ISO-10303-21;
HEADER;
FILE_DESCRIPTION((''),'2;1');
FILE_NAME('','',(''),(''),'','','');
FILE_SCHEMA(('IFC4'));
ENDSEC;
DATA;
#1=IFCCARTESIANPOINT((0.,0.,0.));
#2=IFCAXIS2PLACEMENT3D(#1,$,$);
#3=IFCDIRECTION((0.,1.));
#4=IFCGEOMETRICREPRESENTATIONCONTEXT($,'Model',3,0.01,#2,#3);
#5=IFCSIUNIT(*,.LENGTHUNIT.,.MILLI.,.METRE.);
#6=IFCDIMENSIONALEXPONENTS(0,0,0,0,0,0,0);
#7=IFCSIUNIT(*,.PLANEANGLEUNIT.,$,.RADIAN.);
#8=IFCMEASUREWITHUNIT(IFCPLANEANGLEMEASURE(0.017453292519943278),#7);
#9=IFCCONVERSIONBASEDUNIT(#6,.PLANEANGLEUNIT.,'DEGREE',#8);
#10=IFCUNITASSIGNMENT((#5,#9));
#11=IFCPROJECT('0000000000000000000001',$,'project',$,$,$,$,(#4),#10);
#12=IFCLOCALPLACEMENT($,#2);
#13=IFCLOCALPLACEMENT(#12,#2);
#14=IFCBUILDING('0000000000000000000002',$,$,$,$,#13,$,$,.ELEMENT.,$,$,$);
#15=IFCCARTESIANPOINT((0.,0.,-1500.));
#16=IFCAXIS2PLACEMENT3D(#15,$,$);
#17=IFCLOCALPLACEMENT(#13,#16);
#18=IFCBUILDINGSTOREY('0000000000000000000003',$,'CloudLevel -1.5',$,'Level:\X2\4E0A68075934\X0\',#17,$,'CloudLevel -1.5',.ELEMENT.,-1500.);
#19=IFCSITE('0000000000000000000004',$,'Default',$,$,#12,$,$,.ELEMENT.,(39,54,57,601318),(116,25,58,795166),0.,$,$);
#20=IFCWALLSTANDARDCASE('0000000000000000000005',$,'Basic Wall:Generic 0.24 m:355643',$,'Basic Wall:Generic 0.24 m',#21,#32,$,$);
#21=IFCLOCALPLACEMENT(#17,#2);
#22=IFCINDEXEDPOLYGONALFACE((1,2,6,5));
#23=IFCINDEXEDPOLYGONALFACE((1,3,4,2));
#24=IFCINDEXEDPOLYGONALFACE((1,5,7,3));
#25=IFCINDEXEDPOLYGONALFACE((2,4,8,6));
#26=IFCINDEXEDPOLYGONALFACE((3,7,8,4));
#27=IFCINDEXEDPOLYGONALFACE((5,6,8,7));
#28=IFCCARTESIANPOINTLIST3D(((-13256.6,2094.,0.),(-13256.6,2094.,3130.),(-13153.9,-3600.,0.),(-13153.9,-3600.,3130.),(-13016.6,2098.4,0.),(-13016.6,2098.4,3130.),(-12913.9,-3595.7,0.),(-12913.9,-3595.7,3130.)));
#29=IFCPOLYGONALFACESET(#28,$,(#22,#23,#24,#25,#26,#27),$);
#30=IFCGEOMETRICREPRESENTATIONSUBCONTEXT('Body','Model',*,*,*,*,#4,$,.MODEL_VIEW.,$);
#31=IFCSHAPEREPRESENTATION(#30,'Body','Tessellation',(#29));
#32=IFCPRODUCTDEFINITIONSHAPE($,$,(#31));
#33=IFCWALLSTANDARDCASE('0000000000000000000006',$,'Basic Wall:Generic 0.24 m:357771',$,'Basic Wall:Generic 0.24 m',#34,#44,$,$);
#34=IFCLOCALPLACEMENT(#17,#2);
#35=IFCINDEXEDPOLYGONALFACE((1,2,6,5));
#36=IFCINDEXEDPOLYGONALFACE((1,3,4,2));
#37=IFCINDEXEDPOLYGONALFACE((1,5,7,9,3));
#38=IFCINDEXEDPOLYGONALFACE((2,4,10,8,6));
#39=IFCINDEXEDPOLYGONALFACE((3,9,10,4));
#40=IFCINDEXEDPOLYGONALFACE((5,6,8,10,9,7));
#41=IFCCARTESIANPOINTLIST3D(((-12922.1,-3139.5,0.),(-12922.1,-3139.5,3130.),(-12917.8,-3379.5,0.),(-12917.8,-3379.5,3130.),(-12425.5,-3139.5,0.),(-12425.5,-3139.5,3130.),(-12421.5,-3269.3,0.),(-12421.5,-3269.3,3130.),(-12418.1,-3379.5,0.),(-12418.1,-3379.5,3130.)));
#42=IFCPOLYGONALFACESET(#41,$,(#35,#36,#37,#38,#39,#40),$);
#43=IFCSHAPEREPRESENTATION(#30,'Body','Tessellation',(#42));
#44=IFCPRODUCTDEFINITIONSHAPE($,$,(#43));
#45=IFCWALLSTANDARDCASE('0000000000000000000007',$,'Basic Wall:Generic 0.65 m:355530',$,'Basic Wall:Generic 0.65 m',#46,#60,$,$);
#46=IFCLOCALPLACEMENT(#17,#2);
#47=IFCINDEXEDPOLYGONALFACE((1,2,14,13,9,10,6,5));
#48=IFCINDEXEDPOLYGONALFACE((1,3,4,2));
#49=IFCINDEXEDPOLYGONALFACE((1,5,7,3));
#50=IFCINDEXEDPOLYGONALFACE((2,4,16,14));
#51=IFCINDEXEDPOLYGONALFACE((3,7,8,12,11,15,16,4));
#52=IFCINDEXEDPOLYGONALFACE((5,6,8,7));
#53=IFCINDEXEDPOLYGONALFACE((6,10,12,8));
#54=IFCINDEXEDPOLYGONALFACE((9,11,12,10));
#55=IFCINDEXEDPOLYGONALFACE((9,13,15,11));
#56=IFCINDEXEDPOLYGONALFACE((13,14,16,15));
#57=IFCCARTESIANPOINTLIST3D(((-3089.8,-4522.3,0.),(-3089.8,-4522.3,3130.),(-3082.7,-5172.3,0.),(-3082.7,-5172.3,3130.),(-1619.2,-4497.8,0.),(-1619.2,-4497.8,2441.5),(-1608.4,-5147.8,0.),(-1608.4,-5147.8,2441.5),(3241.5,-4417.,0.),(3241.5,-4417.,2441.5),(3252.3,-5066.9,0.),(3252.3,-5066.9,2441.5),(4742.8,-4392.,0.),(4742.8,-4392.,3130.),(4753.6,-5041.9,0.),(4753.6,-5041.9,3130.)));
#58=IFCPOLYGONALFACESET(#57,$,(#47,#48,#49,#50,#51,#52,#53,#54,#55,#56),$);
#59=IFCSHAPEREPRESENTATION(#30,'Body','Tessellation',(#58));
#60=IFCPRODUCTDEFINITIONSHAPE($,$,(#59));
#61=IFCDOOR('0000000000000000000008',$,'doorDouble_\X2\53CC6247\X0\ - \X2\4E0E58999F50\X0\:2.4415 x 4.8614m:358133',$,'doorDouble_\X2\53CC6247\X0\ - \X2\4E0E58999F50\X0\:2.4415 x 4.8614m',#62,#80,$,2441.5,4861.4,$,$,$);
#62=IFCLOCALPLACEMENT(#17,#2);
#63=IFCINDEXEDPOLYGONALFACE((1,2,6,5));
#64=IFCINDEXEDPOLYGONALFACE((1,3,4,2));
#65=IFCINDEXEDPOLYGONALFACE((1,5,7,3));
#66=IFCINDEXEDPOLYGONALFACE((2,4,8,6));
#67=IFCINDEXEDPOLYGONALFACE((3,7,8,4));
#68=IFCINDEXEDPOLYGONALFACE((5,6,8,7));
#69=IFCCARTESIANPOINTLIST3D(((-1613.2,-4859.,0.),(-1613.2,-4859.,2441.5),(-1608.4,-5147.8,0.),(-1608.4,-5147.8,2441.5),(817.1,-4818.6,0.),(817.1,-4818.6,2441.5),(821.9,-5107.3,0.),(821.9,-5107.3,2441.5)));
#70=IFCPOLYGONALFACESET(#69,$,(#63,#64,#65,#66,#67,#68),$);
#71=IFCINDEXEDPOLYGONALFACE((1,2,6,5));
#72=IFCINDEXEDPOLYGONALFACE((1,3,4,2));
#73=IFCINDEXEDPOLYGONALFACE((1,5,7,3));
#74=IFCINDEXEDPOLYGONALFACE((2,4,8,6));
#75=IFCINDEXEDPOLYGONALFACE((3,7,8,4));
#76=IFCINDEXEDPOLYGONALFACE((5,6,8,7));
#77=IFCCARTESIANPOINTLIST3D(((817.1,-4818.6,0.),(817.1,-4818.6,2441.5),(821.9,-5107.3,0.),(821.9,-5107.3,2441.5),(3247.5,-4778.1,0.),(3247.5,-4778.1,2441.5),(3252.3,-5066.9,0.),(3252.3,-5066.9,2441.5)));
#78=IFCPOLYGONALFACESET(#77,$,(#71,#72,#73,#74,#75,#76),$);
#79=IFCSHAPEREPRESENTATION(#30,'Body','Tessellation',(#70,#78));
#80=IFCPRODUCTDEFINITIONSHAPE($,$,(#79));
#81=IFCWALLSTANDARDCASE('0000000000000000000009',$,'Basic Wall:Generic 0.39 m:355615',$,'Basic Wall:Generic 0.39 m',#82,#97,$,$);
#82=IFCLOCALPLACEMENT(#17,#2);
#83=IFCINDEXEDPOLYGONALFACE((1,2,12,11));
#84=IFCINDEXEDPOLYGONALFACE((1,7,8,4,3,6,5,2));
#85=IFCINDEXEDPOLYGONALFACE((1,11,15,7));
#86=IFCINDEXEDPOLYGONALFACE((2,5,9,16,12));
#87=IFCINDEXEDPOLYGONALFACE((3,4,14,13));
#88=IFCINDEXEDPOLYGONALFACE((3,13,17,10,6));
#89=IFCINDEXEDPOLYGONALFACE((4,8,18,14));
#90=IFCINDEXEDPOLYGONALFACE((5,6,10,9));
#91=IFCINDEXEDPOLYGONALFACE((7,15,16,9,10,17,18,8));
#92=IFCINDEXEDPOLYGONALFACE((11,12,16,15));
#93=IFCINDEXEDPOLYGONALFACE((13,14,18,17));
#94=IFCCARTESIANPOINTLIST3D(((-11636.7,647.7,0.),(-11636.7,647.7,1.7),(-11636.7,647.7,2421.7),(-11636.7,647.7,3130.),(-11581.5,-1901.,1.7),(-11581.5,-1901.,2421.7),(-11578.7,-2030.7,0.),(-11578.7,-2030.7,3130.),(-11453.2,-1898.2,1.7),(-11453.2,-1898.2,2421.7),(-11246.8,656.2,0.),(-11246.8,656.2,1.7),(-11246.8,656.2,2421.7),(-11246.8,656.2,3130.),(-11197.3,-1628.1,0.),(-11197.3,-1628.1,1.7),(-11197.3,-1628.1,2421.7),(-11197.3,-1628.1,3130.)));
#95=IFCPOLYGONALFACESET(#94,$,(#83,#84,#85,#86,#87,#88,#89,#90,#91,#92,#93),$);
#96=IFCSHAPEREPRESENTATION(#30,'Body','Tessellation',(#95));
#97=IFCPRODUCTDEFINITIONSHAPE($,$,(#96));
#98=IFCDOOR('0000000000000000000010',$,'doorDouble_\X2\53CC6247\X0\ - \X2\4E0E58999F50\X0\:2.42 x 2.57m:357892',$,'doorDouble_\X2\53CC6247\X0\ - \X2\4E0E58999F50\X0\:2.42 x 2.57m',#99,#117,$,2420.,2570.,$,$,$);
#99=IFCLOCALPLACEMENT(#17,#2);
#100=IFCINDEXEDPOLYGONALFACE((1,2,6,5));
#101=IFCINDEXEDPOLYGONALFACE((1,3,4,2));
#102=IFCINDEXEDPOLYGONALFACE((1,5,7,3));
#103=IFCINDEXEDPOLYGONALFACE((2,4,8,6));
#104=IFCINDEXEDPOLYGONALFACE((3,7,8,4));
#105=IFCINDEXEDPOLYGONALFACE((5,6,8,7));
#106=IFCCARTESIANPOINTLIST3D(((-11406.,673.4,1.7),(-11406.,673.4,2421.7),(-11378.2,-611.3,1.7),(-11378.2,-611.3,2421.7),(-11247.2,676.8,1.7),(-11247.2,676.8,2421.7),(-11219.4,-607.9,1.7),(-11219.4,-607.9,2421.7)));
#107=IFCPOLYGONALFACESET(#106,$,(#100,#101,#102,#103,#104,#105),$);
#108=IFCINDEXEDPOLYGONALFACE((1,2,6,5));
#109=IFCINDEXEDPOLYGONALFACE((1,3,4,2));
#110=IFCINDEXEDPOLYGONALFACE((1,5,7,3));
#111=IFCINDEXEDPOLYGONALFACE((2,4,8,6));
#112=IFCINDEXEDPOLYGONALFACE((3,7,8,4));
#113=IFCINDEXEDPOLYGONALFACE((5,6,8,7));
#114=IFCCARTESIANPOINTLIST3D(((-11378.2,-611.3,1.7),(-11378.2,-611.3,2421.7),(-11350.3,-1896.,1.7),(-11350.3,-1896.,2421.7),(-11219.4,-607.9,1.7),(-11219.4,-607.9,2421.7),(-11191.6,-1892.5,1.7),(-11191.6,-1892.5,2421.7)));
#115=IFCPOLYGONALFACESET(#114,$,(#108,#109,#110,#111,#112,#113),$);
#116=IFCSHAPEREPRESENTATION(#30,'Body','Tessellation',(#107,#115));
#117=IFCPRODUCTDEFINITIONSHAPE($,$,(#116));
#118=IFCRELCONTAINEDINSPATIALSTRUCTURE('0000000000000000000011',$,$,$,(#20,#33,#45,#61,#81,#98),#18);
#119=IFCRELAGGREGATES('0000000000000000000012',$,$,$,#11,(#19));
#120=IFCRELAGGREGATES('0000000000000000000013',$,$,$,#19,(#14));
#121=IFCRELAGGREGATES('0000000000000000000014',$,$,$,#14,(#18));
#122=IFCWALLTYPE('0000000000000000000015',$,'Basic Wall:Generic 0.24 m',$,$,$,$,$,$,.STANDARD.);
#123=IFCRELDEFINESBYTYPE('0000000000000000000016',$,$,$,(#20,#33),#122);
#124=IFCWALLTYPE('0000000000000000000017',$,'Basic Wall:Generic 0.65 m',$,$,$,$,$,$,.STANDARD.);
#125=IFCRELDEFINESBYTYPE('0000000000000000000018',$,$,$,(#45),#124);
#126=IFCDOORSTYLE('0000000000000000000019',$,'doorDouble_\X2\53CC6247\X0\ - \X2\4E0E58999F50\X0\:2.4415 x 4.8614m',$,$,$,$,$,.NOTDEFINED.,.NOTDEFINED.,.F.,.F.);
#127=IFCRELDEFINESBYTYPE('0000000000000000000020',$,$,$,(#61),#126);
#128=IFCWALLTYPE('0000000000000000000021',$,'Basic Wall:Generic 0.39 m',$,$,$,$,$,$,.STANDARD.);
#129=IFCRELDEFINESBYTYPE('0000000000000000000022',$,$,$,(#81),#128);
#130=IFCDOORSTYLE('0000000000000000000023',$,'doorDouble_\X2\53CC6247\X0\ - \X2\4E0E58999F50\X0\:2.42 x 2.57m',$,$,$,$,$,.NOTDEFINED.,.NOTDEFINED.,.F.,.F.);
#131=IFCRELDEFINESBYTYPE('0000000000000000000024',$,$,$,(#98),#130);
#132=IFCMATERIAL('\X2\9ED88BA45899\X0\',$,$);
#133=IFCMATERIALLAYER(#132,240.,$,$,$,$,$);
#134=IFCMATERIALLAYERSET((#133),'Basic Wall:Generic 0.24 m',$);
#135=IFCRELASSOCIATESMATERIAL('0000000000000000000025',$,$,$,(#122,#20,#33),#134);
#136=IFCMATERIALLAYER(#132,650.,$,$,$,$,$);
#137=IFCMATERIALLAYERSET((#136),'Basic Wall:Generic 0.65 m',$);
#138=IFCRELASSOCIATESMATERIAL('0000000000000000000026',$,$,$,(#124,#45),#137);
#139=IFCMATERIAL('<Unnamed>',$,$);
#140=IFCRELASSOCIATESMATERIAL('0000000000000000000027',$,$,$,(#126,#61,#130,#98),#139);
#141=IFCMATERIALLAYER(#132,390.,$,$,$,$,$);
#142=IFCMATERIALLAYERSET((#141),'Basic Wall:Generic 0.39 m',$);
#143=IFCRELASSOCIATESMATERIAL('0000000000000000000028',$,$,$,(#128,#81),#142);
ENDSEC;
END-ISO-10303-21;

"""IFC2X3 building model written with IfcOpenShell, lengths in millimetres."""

from ifc_helpers import new_model, entity, si_unit, converted_unit, direction, frame, frame_2d, origin, origin_2d_with_axis, place, context, subcontext, project, spatial, polyline, rectangle, outline, extrude, source, transform, mapped, material, layer, layer_set, layer_usage, type_object, type_shapes, element, fill, save


model = new_model("IFC2X3")

# Units and contexts
model_context = context("Model", 3, precision=0.01, world=origin(), true_north=direction((0.0, 1.0)))
body_context = subcontext(model_context, "Body", "Model", "MODEL_VIEW")
ifc_project = project(units=[si_unit("LENGTHUNIT", "METRE", prefix="MILLI"), converted_unit("PLANEANGLEUNIT", "DEGREE", entity("IfcPlaneAngleMeasure", 0.017453292519943278), si_unit("PLANEANGLEUNIT", "RADIAN"), dimensions=[0, 0, 0, 0, 0, 0, 0])], contexts=[model_context])

# Site, building, storey
site_placement = place(None, origin())
site = spatial("IfcSite", under=ifc_project, at=site_placement, Name="Default", CompositionType="ELEMENT", RefLatitude=(39, 54, 57, 601318), RefLongitude=(116, 25, 58, 795166), RefElevation=0.0)
building_placement = place(site_placement, origin())
building = spatial("IfcBuilding", under=site, at=building_placement, CompositionType="ELEMENT")
storey_placement = place(building_placement, frame((0.0, 0.0, -1500.0)))
storey = spatial("IfcBuildingStorey", under=building, at=storey_placement, Name="CloudLevel -1.5", ObjectType="Level:上标头", LongName="CloudLevel -1.5", CompositionType="ELEMENT", Elevation=-1500.0)

# Shared definitions
ifc_material_1 = material(Name="默认墙")
ifc_layer_1 = layer(ifc_material_1, 240.0)
ifc_layer_set_1 = layer_set([ifc_layer_1], Name="Basic Wall:Generic 0.24 m")
ifc_layer_usage_1 = layer_usage(ifc_layer_set_1, "AXIS2", "NEGATIVE", 120.0)
wall_type_1 = type_object("IfcWallType", Name="Basic Wall:Generic 0.24 m", PredefinedType="STANDARD", material=ifc_layer_set_1)

# Walls
wall_1_placement = place(storey_placement, frame((-13033.9, -3597.9, 0.0), z_axis=(0.0, 0.0, 1.0), x_axis=(-0.018033, 0.999837, 0.0)))
element("IfcWallStandardCase", 1, at=wall_1_placement, inside=storey, type_object=wall_type_1, material=ifc_layer_usage_1, Name="Basic Wall:Generic 0.24 m:355643", ObjectType="Basic Wall:Generic 0.24 m", context=body_context, shape_type="SweptSolid", body=[
    extrude(rectangle(XDim=5695.0, YDim=240.0, at=frame_2d((2847.5, 0.0), x_axis=(-1.0, 0.0))), origin(), (0.0, 0.0, 1.0), 3130.0),
])
wall_2_placement = place(storey_placement, frame((-12922.1, -3259.5, 0.0)))
element("IfcWallStandardCase", 2, at=wall_2_placement, inside=storey, type_object=wall_type_1, material=ifc_layer_usage_1, Name="Basic Wall:Generic 0.24 m:357771", ObjectType="Basic Wall:Generic 0.24 m", context=body_context, shape_type="SweptSolid", body=[
    extrude(outline(polyline([(504.0, -120.0), (500.6, -9.8), (496.6, 120.0), (0.0, 120.0), (4.3, -120.0), (504.0, -120.0)])), origin(), (0.0, 0.0, 1.0), 3130.0),
])

# Walls, openings, doors
ifc_layer_2 = layer(ifc_material_1, 650.0)
ifc_layer_set_2 = layer_set([ifc_layer_2], Name="Basic Wall:Generic 0.65 m")
ifc_layer_usage_2 = layer_usage(ifc_layer_set_2, "AXIS2", "NEGATIVE", 325.0)
wall_type_2 = type_object("IfcWallType", Name="Basic Wall:Generic 0.65 m", PredefinedType="STANDARD", material=ifc_layer_set_2)
wall_3_placement = place(storey_placement, frame((-3088.1, -4847.3, 0.0), z_axis=(0.0, 0.0, 1.0), x_axis=(0.999862, 0.016639, 0.0)))
wall_3 = element("IfcWallStandardCase", 3, at=wall_3_placement, inside=storey, type_object=wall_type_2, material=ifc_layer_usage_2, Name="Basic Wall:Generic 0.65 m:355530", ObjectType="Basic Wall:Generic 0.65 m", context=body_context, shape_type="SweptSolid", body=[
    extrude(outline(polyline([(0.0, -325.0), (7837.4, -325.0), (7837.4, 325.0), (3.8, 325.0), (0.3, -273.8), (0.0, -325.0)])), origin(), (0.0, 0.0, 1.0), 3130.0),
])
opening_1_placement = place(wall_3_placement, frame((1474.5, -325.0, 0.0)))
opening_1 = element("IfcOpeningElement", 4, at=opening_1_placement, cuts=wall_3, ObjectType="Opening", context=body_context, shape_type="SweptSolid", body=[
    extrude(rectangle(XDim=2441.5, YDim=4861.4, at=frame_2d((1220.7, 2430.7), x_axis=(1.0, 0.0))), frame((0.0, 0.0, 0.0), z_axis=(0.0, 1.0, 0.0), x_axis=(0.0, 0.0, 1.0)), (0.0, 0.0, 1.0), 650.0),
])
ifc_material_2 = material(Name="<Unnamed>")
door_style_1 = type_object("IfcDoorStyle", Name="doorDouble_双扇 - 与墙齐:2.4415 x 4.8614m", ConstructionType="NOTDEFINED", OperationType="NOTDEFINED", ParameterTakesPrecedence=False, Sizeable=False, material=ifc_material_2)
shared_shape_1 = source(origin(), body_context, "Body", "SweptSolid", [
    extrude(rectangle(XDim=2430.7, YDim=288.8, at=frame_2d((0.0, 0.0), x_axis=(1.0, 0.0))), frame((3646.0, 505.6, 0.0), z_axis=(0.0, 0.0, 1.0), x_axis=(-1.0, 0.0, 0.0)), (0.0, 0.0, 1.0), 2441.5),
    extrude(rectangle(XDim=2430.7, YDim=288.8, at=frame_2d((0.0, 0.0), x_axis=(1.0, 0.0))), frame((1215.3, 505.6, 0.0), z_axis=(0.0, 0.0, 1.0), x_axis=(-1.0, 0.0, 0.0)), (0.0, 0.0, 1.0), 2441.5),
])
type_shapes(door_style_1, [shared_shape_1])
door_1_placement = place(opening_1_placement, frame((4861.4, 650.0, 0.0), z_axis=(0.0, 0.0, 1.0), x_axis=(-1.0, 0.0, 0.0)))
door_1 = element("IfcDoor", 5, at=door_1_placement, inside=storey, type_object=door_style_1, material=ifc_material_2, Name="doorDouble_双扇 - 与墙齐:2.4415 x 4.8614m:358133", ObjectType="doorDouble_双扇 - 与墙齐:2.4415 x 4.8614m", OverallHeight=2441.5, OverallWidth=4861.4, context=body_context, shape_type="MappedRepresentation", body=[
    mapped(shared_shape_1, transform((0.0, 0.0, 0.0), scale=1.0)),
])
fill(opening_1, door_1)
ifc_layer_3 = layer(ifc_material_1, 390.0)
ifc_layer_set_3 = layer_set([ifc_layer_3], Name="Basic Wall:Generic 0.39 m")
ifc_layer_usage_3 = layer_usage(ifc_layer_set_3, "AXIS2", "NEGATIVE", 195.0)
wall_type_3 = type_object("IfcWallType", Name="Basic Wall:Generic 0.39 m", PredefinedType="STANDARD", material=ifc_layer_set_3)
wall_4_placement = place(storey_placement, frame((-11441.7, 652.0, 0.0), z_axis=(0.0, 0.0, 1.0), x_axis=(0.021654, -0.999766, 0.0)))
wall_4 = element("IfcWallStandardCase", 6, at=wall_4_placement, inside=storey, type_object=wall_type_3, material=ifc_layer_usage_3, Name="Basic Wall:Generic 0.39 m:355615", ObjectType="Basic Wall:Generic 0.39 m", context=body_context, shape_type="SweptSolid", body=[
    extrude(outline(polyline([(2679.0, -195.0), (2284.8, 195.0), (0.0, 195.0), (0.0, -195.0), (2679.0, -195.0)])), origin(), (0.0, 0.0, 1.0), 3130.0),
])
opening_2_placement = place(wall_4_placement, frame((-20.7, -195.0, 1.7)))
opening_2 = element("IfcOpeningElement", 7, at=opening_2_placement, cuts=wall_4, ObjectType="Opening", context=body_context, shape_type="SweptSolid", body=[
    extrude(rectangle(XDim=2420.0, YDim=2570.0, at=frame_2d((1210.0, 1285.0), x_axis=(1.0, 0.0))), frame((0.0, 0.0, 0.0), z_axis=(0.0, 1.0, 0.0), x_axis=(0.0, 0.0, 1.0)), (0.0, 0.0, 1.0), 390.0),
])
door_style_2 = type_object("IfcDoorStyle", Name="doorDouble_双扇 - 与墙齐:2.42 x 2.57m", ConstructionType="NOTDEFINED", OperationType="NOTDEFINED", ParameterTakesPrecedence=False, Sizeable=False, material=ifc_material_2)
shared_shape_2 = source(origin(), body_context, "Body", "SweptSolid", [
    extrude(rectangle(XDim=158.8, YDim=1285.0, at=origin_2d_with_axis()), frame((642.5, 310.6, 0.0), z_axis=(0.0, 0.0, 1.0), x_axis=(0.0, -1.0, 0.0)), (0.0, 0.0, 1.0), 2420.0),
    extrude(rectangle(XDim=158.8, YDim=1285.0, at=origin_2d_with_axis()), frame((1927.5, 310.6, 0.0), z_axis=(0.0, 0.0, 1.0), x_axis=(0.0, -1.0, 0.0)), (0.0, 0.0, 1.0), 2420.0),
])
type_shapes(door_style_2, [shared_shape_2])
door_2_placement = place(opening_2_placement, frame((0.0, 0.0, 0.0)))
door_2 = element("IfcDoor", 8, at=door_2_placement, inside=storey, type_object=door_style_2, material=ifc_material_2, Name="doorDouble_双扇 - 与墙齐:2.42 x 2.57m:357892", ObjectType="doorDouble_双扇 - 与墙齐:2.42 x 2.57m", OverallHeight=2420.0, OverallWidth=2570.0, context=body_context, shape_type="MappedRepresentation", body=[
    mapped(shared_shape_2, transform((0.0, 0.0, 0.0), scale=1.0)),
])
fill(opening_2, door_2)

save(model, "model.ifc")
